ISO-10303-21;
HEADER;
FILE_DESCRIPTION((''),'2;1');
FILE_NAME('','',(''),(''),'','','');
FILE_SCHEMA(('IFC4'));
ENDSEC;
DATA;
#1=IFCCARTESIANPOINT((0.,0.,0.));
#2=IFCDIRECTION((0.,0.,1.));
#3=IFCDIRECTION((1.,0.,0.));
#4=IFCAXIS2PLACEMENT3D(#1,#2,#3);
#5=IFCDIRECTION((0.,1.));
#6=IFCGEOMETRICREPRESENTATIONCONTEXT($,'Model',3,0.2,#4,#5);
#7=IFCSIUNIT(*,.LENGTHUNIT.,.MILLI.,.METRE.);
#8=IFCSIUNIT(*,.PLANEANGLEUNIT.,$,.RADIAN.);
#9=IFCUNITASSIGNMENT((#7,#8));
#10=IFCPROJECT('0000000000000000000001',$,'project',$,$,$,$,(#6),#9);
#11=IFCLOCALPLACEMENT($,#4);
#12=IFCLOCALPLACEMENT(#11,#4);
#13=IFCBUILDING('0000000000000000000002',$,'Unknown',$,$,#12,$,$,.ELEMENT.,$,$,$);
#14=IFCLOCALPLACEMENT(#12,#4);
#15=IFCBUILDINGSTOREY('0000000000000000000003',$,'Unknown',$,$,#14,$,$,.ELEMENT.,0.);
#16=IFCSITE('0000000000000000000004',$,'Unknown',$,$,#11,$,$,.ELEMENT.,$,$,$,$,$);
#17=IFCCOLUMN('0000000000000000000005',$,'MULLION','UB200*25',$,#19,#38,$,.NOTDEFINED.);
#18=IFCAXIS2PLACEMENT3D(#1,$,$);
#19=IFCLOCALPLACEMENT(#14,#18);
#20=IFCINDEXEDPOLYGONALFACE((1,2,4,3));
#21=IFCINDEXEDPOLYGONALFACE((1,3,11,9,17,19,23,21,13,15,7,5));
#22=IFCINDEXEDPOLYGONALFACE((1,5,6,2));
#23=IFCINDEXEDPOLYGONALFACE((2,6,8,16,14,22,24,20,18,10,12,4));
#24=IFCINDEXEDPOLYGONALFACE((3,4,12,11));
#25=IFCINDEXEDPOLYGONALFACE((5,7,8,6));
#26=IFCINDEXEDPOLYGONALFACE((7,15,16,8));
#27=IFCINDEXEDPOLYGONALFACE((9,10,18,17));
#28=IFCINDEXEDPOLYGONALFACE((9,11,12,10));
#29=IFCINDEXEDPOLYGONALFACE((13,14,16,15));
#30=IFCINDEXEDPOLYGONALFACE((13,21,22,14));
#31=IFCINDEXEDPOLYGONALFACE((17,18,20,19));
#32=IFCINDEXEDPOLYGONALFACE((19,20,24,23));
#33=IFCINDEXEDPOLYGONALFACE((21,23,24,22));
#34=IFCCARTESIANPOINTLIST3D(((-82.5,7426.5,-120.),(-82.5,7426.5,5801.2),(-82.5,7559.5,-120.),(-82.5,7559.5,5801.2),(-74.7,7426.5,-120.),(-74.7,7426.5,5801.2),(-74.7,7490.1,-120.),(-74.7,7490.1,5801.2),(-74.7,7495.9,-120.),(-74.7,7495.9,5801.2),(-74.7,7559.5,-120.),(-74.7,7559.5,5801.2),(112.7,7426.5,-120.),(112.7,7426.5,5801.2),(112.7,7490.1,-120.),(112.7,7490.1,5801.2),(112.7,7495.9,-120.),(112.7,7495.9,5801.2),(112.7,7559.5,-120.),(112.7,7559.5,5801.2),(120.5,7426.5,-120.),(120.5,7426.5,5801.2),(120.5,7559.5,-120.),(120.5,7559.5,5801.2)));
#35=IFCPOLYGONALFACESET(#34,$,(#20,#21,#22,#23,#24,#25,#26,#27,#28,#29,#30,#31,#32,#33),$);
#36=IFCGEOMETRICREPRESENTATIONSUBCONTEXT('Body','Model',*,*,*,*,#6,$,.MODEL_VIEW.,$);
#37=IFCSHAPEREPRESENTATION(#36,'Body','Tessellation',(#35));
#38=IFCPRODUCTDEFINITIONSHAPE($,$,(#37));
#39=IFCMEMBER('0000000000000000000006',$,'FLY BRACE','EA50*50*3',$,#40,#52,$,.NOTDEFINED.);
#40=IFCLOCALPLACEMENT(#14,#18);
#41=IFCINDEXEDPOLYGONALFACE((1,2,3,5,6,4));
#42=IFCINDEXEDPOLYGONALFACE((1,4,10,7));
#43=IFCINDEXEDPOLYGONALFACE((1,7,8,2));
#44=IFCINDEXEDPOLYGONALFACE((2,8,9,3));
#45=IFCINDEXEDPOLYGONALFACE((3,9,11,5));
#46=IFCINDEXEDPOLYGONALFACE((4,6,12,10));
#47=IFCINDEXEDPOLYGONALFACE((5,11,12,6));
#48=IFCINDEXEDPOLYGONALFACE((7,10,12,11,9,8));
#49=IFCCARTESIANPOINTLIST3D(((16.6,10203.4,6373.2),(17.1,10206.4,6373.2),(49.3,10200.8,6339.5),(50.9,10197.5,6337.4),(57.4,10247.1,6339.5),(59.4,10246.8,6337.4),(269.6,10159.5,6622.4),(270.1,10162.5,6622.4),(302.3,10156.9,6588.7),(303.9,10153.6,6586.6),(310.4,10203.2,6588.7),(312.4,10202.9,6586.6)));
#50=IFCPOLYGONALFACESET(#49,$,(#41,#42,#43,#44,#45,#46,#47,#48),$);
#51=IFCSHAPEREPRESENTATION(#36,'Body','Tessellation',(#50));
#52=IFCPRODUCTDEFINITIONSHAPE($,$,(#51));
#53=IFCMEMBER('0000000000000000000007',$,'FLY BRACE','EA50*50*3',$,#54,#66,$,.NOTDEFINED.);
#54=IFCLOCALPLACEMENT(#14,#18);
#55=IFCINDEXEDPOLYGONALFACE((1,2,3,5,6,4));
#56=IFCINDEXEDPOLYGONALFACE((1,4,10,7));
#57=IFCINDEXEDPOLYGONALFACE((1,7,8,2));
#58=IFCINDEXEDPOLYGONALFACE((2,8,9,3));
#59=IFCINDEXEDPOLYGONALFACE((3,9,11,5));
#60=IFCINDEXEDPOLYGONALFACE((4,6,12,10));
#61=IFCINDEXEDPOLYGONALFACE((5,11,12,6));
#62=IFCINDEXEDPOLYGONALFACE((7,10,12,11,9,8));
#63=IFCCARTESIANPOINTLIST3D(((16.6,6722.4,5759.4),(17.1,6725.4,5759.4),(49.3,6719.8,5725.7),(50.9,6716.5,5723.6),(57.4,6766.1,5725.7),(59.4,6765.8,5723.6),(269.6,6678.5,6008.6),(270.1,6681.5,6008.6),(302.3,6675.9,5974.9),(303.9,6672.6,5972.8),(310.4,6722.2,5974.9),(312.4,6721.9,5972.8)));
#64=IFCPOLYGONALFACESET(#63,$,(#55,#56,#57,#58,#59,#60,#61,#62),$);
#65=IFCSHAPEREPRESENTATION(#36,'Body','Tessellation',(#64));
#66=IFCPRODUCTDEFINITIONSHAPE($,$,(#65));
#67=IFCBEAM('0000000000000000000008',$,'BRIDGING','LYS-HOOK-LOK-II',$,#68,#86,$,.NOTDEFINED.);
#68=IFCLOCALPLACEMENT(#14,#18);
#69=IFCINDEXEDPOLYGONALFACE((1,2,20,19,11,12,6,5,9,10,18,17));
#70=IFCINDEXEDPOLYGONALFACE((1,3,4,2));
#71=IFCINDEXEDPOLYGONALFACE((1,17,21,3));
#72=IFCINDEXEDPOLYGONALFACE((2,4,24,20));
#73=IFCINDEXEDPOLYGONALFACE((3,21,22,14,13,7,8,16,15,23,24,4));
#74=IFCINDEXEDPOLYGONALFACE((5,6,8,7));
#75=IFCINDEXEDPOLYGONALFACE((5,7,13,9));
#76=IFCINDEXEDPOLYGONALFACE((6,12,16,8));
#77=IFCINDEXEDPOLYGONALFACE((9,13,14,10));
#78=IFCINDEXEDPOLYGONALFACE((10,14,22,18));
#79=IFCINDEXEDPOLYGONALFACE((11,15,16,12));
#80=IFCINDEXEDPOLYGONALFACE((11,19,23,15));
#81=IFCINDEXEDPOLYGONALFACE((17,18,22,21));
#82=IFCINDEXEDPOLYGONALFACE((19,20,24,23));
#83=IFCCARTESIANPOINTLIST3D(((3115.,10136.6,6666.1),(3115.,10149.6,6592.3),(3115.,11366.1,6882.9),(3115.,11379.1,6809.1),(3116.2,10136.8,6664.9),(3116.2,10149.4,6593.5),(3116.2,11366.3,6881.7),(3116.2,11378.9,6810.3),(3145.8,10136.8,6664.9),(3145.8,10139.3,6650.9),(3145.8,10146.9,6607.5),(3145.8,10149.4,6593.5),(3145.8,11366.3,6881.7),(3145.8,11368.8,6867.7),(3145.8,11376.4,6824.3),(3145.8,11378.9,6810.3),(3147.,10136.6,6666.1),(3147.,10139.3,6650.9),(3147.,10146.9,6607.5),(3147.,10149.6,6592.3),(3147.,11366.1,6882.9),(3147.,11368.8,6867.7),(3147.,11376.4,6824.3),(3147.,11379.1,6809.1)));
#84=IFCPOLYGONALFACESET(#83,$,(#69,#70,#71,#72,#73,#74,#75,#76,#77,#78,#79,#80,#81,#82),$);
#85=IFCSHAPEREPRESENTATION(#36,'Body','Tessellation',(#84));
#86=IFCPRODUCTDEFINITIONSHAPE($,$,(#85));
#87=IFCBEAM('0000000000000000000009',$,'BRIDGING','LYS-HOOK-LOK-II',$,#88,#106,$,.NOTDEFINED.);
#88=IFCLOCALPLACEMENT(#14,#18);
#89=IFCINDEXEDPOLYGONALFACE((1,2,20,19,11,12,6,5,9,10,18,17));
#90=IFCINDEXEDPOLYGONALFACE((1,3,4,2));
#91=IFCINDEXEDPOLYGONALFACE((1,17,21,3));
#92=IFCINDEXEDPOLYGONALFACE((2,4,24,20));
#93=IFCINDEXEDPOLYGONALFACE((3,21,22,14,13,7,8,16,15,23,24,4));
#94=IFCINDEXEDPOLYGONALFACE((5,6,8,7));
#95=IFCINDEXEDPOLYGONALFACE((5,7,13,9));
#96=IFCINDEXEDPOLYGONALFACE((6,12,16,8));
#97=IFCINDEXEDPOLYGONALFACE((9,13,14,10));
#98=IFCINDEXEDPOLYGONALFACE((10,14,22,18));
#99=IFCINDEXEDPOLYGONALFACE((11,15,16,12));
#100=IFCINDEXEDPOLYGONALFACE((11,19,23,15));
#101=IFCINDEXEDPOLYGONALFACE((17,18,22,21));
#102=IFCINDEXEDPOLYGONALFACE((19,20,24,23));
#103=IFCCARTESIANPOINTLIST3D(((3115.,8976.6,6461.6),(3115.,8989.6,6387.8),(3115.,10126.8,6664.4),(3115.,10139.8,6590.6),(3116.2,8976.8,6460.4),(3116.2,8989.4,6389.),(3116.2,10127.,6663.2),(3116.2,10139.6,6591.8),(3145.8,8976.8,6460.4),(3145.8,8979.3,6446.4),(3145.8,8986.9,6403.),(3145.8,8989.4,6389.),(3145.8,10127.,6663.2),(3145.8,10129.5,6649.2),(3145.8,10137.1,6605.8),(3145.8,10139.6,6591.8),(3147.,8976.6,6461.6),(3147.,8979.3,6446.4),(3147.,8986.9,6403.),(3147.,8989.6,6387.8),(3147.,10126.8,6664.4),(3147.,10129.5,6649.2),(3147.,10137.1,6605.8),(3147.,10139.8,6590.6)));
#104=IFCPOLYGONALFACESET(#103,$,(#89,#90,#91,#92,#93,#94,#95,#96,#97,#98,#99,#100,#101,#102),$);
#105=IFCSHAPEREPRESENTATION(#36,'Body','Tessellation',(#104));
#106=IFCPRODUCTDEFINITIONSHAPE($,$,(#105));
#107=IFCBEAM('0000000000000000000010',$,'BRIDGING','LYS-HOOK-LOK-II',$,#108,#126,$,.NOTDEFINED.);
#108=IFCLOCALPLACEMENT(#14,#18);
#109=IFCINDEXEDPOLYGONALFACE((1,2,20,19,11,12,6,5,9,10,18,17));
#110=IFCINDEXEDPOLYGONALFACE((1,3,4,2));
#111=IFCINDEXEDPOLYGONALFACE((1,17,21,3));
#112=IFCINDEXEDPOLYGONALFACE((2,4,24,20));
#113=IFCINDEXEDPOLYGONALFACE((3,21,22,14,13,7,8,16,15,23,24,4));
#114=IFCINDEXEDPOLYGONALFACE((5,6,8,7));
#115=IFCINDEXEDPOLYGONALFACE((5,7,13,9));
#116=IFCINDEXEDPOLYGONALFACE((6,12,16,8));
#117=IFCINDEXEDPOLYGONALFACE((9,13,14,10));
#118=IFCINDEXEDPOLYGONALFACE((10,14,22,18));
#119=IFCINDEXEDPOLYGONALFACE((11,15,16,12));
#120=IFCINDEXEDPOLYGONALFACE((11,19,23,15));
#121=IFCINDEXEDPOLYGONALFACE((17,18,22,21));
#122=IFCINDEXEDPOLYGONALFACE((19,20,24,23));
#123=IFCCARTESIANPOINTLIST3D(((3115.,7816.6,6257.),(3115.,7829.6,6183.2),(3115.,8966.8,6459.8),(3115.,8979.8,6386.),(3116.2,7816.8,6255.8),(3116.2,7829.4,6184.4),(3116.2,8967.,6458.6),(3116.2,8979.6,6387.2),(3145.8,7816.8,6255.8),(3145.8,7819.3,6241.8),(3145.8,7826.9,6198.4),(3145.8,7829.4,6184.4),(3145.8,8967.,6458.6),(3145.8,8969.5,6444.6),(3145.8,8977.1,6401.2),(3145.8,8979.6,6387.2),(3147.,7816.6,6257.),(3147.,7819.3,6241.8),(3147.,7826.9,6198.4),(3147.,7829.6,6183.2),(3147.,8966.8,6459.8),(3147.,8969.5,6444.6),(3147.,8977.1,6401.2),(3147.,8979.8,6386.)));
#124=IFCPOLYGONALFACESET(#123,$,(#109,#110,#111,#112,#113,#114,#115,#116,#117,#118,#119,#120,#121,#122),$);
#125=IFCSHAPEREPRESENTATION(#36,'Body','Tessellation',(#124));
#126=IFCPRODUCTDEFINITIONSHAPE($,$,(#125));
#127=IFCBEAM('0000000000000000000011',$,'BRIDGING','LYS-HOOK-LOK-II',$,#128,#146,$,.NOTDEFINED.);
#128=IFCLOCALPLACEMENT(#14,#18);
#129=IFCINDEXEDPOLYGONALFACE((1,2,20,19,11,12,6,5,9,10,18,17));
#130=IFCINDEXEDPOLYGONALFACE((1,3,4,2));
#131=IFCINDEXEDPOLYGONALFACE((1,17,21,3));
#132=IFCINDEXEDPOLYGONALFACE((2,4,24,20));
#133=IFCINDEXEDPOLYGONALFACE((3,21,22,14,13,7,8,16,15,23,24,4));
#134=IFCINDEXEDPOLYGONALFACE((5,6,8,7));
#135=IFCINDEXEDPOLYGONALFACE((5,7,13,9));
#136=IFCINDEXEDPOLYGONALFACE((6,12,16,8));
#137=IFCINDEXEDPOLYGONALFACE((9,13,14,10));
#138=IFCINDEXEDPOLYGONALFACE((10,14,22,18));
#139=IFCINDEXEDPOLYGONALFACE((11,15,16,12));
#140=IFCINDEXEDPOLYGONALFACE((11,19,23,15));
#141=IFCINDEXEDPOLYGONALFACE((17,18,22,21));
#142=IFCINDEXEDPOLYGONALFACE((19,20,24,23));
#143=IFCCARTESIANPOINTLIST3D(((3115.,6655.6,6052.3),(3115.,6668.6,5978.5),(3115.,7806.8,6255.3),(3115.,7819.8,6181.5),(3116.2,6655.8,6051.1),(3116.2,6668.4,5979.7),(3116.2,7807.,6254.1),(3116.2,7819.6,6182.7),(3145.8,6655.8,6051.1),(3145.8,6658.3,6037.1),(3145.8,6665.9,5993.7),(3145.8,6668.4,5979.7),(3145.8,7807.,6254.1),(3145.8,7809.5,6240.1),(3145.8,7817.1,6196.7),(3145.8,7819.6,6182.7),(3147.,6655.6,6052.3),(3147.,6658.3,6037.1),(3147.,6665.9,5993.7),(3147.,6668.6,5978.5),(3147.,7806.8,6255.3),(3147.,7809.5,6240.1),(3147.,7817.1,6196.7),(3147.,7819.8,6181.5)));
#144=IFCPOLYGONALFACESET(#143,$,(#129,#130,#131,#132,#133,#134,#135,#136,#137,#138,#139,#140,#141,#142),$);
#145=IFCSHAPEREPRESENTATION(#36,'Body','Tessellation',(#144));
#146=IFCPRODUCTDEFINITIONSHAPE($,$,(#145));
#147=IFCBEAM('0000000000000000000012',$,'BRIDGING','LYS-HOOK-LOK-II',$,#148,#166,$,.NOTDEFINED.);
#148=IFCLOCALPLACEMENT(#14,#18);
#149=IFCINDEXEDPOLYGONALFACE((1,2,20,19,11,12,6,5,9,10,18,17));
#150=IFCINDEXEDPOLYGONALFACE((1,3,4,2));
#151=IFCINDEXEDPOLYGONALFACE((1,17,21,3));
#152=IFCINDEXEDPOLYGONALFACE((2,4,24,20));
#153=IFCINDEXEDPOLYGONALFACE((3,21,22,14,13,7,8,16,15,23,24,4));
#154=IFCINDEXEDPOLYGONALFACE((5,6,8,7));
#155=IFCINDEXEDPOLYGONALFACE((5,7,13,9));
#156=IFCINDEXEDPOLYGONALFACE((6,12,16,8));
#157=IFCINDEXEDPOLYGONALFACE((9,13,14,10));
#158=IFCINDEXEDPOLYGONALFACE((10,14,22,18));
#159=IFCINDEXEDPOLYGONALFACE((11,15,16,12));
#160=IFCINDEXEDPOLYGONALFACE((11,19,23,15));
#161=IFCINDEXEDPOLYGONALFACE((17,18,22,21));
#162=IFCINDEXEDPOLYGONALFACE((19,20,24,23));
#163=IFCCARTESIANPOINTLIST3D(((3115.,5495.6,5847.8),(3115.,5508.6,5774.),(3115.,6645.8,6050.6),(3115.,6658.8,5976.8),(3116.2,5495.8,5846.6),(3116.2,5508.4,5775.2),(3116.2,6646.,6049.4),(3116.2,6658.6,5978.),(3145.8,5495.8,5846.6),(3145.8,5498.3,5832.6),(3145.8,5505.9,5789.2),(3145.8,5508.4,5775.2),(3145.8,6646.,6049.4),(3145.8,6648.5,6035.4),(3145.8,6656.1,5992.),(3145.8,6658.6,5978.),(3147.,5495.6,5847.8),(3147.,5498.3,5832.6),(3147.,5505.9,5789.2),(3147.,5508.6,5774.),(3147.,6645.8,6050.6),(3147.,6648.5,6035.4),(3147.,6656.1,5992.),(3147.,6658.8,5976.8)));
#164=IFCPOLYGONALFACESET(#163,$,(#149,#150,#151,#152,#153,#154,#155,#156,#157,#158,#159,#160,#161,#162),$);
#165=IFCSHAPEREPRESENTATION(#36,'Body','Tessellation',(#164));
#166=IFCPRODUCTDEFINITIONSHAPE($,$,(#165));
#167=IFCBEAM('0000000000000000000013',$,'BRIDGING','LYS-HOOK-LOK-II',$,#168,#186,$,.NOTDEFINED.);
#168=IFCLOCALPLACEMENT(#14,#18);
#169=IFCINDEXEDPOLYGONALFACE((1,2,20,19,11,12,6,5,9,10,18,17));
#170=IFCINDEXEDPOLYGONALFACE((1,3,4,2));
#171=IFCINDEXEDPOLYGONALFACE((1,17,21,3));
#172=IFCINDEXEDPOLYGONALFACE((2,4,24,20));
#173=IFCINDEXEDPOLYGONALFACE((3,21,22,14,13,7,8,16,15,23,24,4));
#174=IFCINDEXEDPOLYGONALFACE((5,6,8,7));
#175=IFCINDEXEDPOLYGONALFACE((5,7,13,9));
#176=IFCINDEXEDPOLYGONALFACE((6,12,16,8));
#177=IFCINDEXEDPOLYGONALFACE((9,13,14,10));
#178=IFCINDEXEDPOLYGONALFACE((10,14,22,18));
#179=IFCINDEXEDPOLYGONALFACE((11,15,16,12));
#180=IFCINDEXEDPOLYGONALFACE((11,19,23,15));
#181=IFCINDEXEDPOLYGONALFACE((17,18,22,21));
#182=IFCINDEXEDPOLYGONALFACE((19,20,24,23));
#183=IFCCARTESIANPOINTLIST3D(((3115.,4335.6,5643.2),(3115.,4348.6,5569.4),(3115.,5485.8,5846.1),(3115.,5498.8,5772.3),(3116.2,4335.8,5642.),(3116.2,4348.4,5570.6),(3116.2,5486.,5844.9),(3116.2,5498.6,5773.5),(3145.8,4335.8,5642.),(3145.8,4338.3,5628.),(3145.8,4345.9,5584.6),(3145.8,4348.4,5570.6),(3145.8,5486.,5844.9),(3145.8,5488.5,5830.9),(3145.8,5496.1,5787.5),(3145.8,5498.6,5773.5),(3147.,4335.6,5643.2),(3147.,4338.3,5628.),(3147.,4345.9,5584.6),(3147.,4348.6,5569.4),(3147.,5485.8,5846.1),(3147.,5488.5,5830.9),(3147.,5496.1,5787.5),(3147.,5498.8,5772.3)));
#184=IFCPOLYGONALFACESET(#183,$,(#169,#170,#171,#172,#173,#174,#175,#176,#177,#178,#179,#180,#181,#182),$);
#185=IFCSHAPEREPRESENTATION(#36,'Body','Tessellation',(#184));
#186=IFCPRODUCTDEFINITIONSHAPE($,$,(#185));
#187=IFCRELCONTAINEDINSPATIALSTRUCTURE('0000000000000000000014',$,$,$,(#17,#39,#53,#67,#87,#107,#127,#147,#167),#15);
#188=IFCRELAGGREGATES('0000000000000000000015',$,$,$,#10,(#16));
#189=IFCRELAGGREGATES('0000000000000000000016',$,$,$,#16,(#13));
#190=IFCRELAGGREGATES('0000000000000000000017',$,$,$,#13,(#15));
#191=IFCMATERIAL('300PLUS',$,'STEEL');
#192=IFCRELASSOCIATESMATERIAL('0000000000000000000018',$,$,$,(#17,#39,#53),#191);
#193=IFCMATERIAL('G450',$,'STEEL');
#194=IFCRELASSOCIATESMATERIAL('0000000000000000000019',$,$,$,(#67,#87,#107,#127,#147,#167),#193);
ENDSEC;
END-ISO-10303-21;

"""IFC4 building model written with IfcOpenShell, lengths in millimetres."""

from ifc_helpers import new_model, si_unit, direction, frame, origin_with_axes, place, context, subcontext, project, spatial, line, indexed_curve, outline, extrude, material, element, save


model = new_model("IFC4")

# Units and contexts
model_context = context("Model", 3, precision=0.2, world=origin_with_axes(), true_north=direction((0.0, 1.0)))
body_context = subcontext(model_context, "Body", "Model", "MODEL_VIEW")
ifc_project = project(units=[si_unit("LENGTHUNIT", "METRE", prefix="MILLI"), si_unit("PLANEANGLEUNIT", "RADIAN")], contexts=[model_context])

# Site, building, storey
site_placement = place(None, origin_with_axes())
site = spatial("IfcSite", under=ifc_project, at=site_placement, Name="Unknown", CompositionType="ELEMENT")
building_placement = place(site_placement, origin_with_axes())
building = spatial("IfcBuilding", under=site, at=building_placement, Name="Unknown", CompositionType="ELEMENT")
storey_placement = place(building_placement, origin_with_axes())
storey = spatial("IfcBuildingStorey", under=building, at=storey_placement, Name="Unknown", CompositionType="ELEMENT", Elevation=0.0)

# Column
ifc_material_1 = material(Name="300PLUS", Category="STEEL")
column_placement = place(storey_placement, frame((19.0, 7493.0, -120.0), z_axis=(0.0, -1.0, 0.0), x_axis=(0.0, 0.0, 1.0)))
element("IfcColumn", 1, at=column_placement, inside=storey, material=ifc_material_1, Name="MULLION", Description="UB200*25", PredefinedType="NOTDEFINED", context=body_context, shape_type="SolidModel", body=[
    extrude(outline(indexed_curve([(-66.5, -101.5), (66.5, -101.5), (66.5, -93.7), (2.9, -93.7), (2.9, 93.7), (66.5, 93.7), (66.5, 101.5), (-66.5, 101.5), (-66.5, 93.7), (-2.9, 93.7), (-2.9, -93.7), (-66.5, -93.7)], segments=[line(1, 2, 3, 4, 5, 6, 7, 8, 9, 10, 11, 12, 1)])), frame((0.0, 0.0, 0.0), z_axis=(-1.0, 0.0, 0.0), x_axis=(0.0, 0.0, 1.0)), (0.0, 0.0, -1.0), 5921.2),
])

# Members
for number, where, z_axis, x_axis, name in (
    (2, (291.0, 10181.2, 6604.5), (0.170963, 0.985277, 0.0), (-0.707055, 0.122687, -0.696435), "FLY BRACE"),
    (3, (291.0, 6700.2, 5990.7), (0.170963, 0.985277, 0.0), (-0.707055, 0.122687, -0.696435), "FLY BRACE"),
):
    element("IfcMember", number, at=place(storey_placement, frame(where, z_axis=z_axis, x_axis=x_axis)), inside=storey, material=ifc_material_1, Name=name, Description="EA50*50*3", PredefinedType="NOTDEFINED", context=body_context, shape_type="SolidModel", body=[
        extrude(outline(indexed_curve([(-25.0, -25.0), (25.0, -25.0), (25.0, -22.0), (-22.0, -22.0), (-22.0, 25.0), (-25.0, 25.0)], segments=[line(1, 2, 3, 4, 5, 6, 1)])), frame((0.0, 0.0, 0.0), z_axis=(-1.0, 0.0, 0.0), x_axis=(0.0, 0.0, 1.0)), (0.0, 0.0, -1.0), 357.8),
    ])

# Beams
ifc_material_2 = material(Name="G450", Category="STEEL")
beam_1_placement = place(storey_placement, frame((3131.0, 10143.1, 6629.2), z_axis=(1.0, 0.0, 0.0), x_axis=(0.0, 0.984807, 0.173653)))
element("IfcBeam", 4, at=beam_1_placement, inside=storey, material=ifc_material_2, Name="BRIDGING", Description="LYS-HOOK-LOK-II", PredefinedType="NOTDEFINED", context=body_context, shape_type="SolidModel", body=[
    extrude(outline(indexed_curve([(16.0, -37.5), (16.0, -22.0), (14.8, -22.0), (14.8, -36.3), (-14.8, -36.3), (-14.8, 36.3), (14.8, 36.3), (14.8, 22.0), (16.0, 22.0), (16.0, 37.5), (-16.0, 37.5), (-16.0, -37.5)], segments=[line(1, 2, 3, 4, 5, 6, 7, 8, 9, 10, 11, 12, 1)])), frame((0.0, 0.0, 0.0), z_axis=(-1.0, 0.0, 0.0), x_axis=(0.0, 0.0, 1.0)), (0.0, 0.0, -1.0), 1248.5),
])
for number, where, z_axis, x_axis, name in (
    (5, (3131.0, 8983.1, 6424.7), (1.0, 0.0, 0.0), (0.0, 0.984809, 0.173639), "BRIDGING"),
    (6, (3131.0, 7823.1, 6220.1), (1.0, 0.0, 0.0), (0.0, 0.984809, 0.173639), "BRIDGING"),
):
    element("IfcBeam", number, at=place(storey_placement, frame(where, z_axis=z_axis, x_axis=x_axis)), inside=storey, material=ifc_material_2, Name=name, Description="LYS-HOOK-LOK-II", PredefinedType="NOTDEFINED", context=body_context, shape_type="SolidModel", body=[
        extrude(outline(indexed_curve([(16.0, -37.5), (16.0, -22.0), (14.8, -22.0), (14.8, -36.3), (-14.8, -36.3), (-14.8, 36.3), (14.8, 36.3), (14.8, 22.0), (16.0, 22.0), (16.0, 37.5), (-16.0, 37.5), (-16.0, -37.5)], segments=[line(1, 2, 3, 4, 5, 6, 7, 8, 9, 10, 11, 12, 1)])), frame((0.0, 0.0, 0.0), z_axis=(-1.0, 0.0, 0.0), x_axis=(0.0, 0.0, 1.0)), (0.0, 0.0, -1.0), 1167.9),
    ])
beam_2_placement = place(storey_placement, frame((3131.0, 6662.1, 6015.4), z_axis=(1.0, 0.0, 0.0), x_axis=(0.0, 0.984806, 0.173658)))
element("IfcBeam", 7, at=beam_2_placement, inside=storey, material=ifc_material_2, Name="BRIDGING", Description="LYS-HOOK-LOK-II", PredefinedType="NOTDEFINED", context=body_context, shape_type="SolidModel", body=[
    extrude(outline(indexed_curve([(16.0, -37.5), (16.0, -22.0), (14.8, -22.0), (14.8, -36.3), (-14.8, -36.3), (-14.8, 36.3), (14.8, 36.3), (14.8, 22.0), (16.0, 22.0), (16.0, 37.5), (-16.0, 37.5), (-16.0, -37.5)], segments=[line(1, 2, 3, 4, 5, 6, 7, 8, 9, 10, 11, 12, 1)])), frame((0.0, 0.0, 0.0), z_axis=(-1.0, 0.0, 0.0), x_axis=(0.0, 0.0, 1.0)), (0.0, 0.0, -1.0), 1169.0),
])
beam_3_placement = place(storey_placement, frame((3131.0, 5502.1, 5810.9), z_axis=(1.0, 0.0, 0.0), x_axis=(0.0, 0.984809, 0.173639)))
element("IfcBeam", 8, at=beam_3_placement, inside=storey, material=ifc_material_2, Name="BRIDGING", Description="LYS-HOOK-LOK-II", PredefinedType="NOTDEFINED", context=body_context, shape_type="SolidModel", body=[
    extrude(outline(indexed_curve([(16.0, -37.5), (16.0, -22.0), (14.8, -22.0), (14.8, -36.3), (-14.8, -36.3), (-14.8, 36.3), (14.8, 36.3), (14.8, 22.0), (16.0, 22.0), (16.0, 37.5), (-16.0, 37.5), (-16.0, -37.5)], segments=[line(1, 2, 3, 4, 5, 6, 7, 8, 9, 10, 11, 12, 1)])), frame((0.0, 0.0, 0.0), z_axis=(-1.0, 0.0, 0.0), x_axis=(0.0, 0.0, 1.0)), (0.0, 0.0, -1.0), 1167.9),
])
beam_4_placement = place(storey_placement, frame((3131.0, 4342.1, 5606.3), z_axis=(1.0, 0.0, 0.0), x_axis=(0.0, 0.984795, 0.173722)))
element("IfcBeam", 9, at=beam_4_placement, inside=storey, material=ifc_material_2, Name="BRIDGING", Description="LYS-HOOK-LOK-II", PredefinedType="NOTDEFINED", context=body_context, shape_type="SolidModel", body=[
    extrude(outline(indexed_curve([(16.0, -37.5), (16.0, -22.0), (14.8, -22.0), (14.8, -36.3), (-14.8, -36.3), (-14.8, 36.3), (14.8, 36.3), (14.8, 22.0), (16.0, 22.0), (16.0, 37.5), (-16.0, 37.5), (-16.0, -37.5)], segments=[line(1, 2, 3, 4, 5, 6, 7, 8, 9, 10, 11, 12, 1)])), frame((0.0, 0.0, 0.0), z_axis=(-1.0, 0.0, 0.0), x_axis=(0.0, 0.0, 1.0)), (0.0, 0.0, -1.0), 1168.0),
])

save(model, "model.ifc")
